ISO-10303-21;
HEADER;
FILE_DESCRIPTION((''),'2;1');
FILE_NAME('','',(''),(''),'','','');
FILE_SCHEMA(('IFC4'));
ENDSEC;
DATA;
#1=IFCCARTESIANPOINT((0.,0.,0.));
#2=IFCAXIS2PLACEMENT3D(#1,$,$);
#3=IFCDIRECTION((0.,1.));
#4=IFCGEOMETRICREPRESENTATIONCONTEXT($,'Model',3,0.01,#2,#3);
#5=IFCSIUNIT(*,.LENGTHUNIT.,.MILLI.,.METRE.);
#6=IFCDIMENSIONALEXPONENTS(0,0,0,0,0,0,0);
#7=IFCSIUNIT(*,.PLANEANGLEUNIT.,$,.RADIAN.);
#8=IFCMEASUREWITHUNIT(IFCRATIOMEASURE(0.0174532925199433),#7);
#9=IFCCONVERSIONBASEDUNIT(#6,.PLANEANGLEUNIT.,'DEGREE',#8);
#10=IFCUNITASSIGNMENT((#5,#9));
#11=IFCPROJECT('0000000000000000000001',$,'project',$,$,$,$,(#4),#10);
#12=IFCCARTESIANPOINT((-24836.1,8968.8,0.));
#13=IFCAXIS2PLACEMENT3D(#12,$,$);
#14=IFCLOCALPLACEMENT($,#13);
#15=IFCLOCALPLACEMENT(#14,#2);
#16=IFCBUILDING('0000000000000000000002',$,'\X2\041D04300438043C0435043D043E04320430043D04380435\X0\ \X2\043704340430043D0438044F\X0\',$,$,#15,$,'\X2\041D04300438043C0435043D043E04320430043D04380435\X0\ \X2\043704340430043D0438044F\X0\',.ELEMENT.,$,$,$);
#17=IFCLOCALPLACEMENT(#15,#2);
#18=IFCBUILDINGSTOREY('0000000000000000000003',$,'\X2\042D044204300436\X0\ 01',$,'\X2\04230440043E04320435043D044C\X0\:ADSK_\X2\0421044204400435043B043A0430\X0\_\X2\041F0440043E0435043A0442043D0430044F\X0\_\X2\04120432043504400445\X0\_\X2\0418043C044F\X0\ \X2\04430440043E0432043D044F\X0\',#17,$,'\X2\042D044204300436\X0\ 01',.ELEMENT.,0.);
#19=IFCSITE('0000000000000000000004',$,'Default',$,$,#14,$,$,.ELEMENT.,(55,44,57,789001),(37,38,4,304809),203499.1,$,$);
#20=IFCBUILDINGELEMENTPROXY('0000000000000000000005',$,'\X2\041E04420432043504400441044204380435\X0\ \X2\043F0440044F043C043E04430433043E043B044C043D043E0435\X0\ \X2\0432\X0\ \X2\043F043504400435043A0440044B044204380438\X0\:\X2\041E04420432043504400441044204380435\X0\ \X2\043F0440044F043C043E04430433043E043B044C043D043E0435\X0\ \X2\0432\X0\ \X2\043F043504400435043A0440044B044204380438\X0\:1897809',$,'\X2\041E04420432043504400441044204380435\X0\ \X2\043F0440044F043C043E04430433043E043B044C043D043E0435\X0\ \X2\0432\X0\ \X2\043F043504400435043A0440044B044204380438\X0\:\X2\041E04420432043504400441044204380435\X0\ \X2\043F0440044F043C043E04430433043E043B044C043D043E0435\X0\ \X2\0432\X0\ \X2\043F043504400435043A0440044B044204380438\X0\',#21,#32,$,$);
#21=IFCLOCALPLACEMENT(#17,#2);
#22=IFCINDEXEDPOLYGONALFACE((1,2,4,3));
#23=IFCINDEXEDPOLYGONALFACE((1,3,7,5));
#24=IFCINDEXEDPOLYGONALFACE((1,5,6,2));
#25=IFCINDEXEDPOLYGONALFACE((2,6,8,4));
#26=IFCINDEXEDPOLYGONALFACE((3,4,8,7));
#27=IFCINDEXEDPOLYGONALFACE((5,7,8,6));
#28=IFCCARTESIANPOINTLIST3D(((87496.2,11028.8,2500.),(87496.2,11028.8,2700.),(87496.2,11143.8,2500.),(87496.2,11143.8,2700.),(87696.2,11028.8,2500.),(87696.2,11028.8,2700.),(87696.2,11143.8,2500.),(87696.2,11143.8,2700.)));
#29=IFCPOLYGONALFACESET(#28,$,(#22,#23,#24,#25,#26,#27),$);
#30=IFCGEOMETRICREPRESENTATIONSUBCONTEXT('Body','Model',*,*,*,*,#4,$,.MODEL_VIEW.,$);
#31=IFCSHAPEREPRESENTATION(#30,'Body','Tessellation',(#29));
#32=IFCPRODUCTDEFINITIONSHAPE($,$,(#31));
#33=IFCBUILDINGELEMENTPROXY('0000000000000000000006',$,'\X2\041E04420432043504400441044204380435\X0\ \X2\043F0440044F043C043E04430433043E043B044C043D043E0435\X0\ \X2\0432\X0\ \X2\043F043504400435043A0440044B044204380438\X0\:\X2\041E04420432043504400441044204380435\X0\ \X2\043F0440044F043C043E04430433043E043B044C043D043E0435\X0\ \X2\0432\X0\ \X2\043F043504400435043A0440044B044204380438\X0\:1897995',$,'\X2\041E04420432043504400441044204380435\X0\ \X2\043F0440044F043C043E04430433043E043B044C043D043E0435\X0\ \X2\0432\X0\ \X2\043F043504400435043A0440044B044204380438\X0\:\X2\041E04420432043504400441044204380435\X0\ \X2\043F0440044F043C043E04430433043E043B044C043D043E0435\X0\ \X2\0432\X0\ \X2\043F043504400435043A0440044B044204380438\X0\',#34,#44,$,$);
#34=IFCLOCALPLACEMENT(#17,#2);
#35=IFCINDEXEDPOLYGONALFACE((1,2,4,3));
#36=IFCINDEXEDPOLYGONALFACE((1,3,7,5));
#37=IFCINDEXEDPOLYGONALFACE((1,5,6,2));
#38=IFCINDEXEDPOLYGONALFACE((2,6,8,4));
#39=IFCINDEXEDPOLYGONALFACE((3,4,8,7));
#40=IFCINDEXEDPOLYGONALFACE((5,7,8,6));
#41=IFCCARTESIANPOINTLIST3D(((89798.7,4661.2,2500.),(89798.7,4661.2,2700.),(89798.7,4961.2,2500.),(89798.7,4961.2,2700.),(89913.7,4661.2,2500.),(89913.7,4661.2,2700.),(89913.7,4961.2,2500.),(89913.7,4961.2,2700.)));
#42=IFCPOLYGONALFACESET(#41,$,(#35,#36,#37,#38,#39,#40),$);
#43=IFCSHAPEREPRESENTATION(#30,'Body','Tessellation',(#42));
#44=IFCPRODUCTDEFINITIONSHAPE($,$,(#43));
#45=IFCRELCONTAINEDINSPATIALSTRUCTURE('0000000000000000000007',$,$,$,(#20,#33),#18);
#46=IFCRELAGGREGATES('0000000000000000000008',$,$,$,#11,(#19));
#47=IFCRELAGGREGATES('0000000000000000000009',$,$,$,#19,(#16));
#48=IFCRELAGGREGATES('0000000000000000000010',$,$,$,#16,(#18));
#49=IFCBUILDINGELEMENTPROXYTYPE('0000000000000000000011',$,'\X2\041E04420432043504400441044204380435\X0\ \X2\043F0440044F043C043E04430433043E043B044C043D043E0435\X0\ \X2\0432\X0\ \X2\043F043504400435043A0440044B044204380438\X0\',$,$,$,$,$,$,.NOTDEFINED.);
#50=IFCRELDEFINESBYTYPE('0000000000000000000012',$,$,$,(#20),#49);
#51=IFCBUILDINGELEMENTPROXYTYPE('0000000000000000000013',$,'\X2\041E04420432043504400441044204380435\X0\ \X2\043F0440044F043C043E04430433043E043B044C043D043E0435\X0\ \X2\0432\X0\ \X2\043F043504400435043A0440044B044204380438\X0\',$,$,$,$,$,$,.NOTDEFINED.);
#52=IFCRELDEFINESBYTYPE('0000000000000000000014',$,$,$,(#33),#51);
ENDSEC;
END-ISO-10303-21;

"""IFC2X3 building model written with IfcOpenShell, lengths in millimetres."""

from ifc_helpers import new_model, entity, si_unit, converted_unit, direction, frame, origin, origin_2d_with_axis, place, context, subcontext, project, spatial, rectangle, extrude, type_object, element, save


model = new_model("IFC2X3")

# Units and contexts
model_context = context("Model", 3, precision=0.01, world=origin(), true_north=direction((0.0, 1.0)))
body_context = subcontext(model_context, "Body", "Model", "MODEL_VIEW")
ifc_project = project(units=[si_unit("LENGTHUNIT", "METRE", prefix="MILLI"), converted_unit("PLANEANGLEUNIT", "DEGREE", entity("IfcRatioMeasure", 0.0174532925199433), si_unit("PLANEANGLEUNIT", "RADIAN"), dimensions=[0, 0, 0, 0, 0, 0, 0])], contexts=[model_context])

# Site, building, storey
site_placement = place(None, frame((-24836.1, 8968.8, 0.0)))
site = spatial("IfcSite", under=ifc_project, at=site_placement, Name="Default", CompositionType="ELEMENT", RefLatitude=(55, 44, 57, 789001), RefLongitude=(37, 38, 4, 304809), RefElevation=203499.1)
building_placement = place(site_placement, origin())
building = spatial("IfcBuilding", under=site, at=building_placement, Name="Наименование здания", LongName="Наименование здания", CompositionType="ELEMENT")
storey_placement = place(building_placement, origin())
storey = spatial("IfcBuildingStorey", under=building, at=storey_placement, Name="Этаж 01", ObjectType="Уровень:ADSK_Стрелка_Проектная_Вверх_Имя уровня", LongName="Этаж 01", CompositionType="ELEMENT", Elevation=0.0)

# Building element proxies
building_element_proxy_type_1 = type_object("IfcBuildingElementProxyType", Name="Отверстие прямоугольное в перекрытии", PredefinedType="NOTDEFINED")
proxy_1_placement = place(storey_placement, frame((87496.2, 11028.8, 2500.0)))
element("IfcBuildingElementProxy", 1, at=proxy_1_placement, inside=storey, type_object=building_element_proxy_type_1, Name="Отверстие прямоугольное в перекрытии:Отверстие прямоугольное в перекрытии:1897809", ObjectType="Отверстие прямоугольное в перекрытии:Отверстие прямоугольное в перекрытии", context=body_context, shape_type="SweptSolid", body=[
    extrude(rectangle(XDim=200.0, YDim=115.0, at=origin_2d_with_axis()), frame((100.0, 57.5, 0.0), z_axis=(0.0, 0.0, 1.0), x_axis=(-1.0, 0.0, 0.0)), (0.0, 0.0, 1.0), 200.0),
])
building_element_proxy_type_2 = type_object("IfcBuildingElementProxyType", Name="Отверстие прямоугольное в перекрытии", PredefinedType="NOTDEFINED")
proxy_2_placement = place(storey_placement, frame((89798.7, 4661.2, 2500.0)))
element("IfcBuildingElementProxy", 2, at=proxy_2_placement, inside=storey, type_object=building_element_proxy_type_2, Name="Отверстие прямоугольное в перекрытии:Отверстие прямоугольное в перекрытии:1897995", ObjectType="Отверстие прямоугольное в перекрытии:Отверстие прямоугольное в перекрытии", context=body_context, shape_type="SweptSolid", body=[
    extrude(rectangle(XDim=300.0, YDim=115.0, at=origin_2d_with_axis()), frame((57.5, 150.0, 0.0), z_axis=(0.0, 0.0, 1.0), x_axis=(0.0, -1.0, 0.0)), (0.0, 0.0, 1.0), 200.0),
])

save(model, "model.ifc")
